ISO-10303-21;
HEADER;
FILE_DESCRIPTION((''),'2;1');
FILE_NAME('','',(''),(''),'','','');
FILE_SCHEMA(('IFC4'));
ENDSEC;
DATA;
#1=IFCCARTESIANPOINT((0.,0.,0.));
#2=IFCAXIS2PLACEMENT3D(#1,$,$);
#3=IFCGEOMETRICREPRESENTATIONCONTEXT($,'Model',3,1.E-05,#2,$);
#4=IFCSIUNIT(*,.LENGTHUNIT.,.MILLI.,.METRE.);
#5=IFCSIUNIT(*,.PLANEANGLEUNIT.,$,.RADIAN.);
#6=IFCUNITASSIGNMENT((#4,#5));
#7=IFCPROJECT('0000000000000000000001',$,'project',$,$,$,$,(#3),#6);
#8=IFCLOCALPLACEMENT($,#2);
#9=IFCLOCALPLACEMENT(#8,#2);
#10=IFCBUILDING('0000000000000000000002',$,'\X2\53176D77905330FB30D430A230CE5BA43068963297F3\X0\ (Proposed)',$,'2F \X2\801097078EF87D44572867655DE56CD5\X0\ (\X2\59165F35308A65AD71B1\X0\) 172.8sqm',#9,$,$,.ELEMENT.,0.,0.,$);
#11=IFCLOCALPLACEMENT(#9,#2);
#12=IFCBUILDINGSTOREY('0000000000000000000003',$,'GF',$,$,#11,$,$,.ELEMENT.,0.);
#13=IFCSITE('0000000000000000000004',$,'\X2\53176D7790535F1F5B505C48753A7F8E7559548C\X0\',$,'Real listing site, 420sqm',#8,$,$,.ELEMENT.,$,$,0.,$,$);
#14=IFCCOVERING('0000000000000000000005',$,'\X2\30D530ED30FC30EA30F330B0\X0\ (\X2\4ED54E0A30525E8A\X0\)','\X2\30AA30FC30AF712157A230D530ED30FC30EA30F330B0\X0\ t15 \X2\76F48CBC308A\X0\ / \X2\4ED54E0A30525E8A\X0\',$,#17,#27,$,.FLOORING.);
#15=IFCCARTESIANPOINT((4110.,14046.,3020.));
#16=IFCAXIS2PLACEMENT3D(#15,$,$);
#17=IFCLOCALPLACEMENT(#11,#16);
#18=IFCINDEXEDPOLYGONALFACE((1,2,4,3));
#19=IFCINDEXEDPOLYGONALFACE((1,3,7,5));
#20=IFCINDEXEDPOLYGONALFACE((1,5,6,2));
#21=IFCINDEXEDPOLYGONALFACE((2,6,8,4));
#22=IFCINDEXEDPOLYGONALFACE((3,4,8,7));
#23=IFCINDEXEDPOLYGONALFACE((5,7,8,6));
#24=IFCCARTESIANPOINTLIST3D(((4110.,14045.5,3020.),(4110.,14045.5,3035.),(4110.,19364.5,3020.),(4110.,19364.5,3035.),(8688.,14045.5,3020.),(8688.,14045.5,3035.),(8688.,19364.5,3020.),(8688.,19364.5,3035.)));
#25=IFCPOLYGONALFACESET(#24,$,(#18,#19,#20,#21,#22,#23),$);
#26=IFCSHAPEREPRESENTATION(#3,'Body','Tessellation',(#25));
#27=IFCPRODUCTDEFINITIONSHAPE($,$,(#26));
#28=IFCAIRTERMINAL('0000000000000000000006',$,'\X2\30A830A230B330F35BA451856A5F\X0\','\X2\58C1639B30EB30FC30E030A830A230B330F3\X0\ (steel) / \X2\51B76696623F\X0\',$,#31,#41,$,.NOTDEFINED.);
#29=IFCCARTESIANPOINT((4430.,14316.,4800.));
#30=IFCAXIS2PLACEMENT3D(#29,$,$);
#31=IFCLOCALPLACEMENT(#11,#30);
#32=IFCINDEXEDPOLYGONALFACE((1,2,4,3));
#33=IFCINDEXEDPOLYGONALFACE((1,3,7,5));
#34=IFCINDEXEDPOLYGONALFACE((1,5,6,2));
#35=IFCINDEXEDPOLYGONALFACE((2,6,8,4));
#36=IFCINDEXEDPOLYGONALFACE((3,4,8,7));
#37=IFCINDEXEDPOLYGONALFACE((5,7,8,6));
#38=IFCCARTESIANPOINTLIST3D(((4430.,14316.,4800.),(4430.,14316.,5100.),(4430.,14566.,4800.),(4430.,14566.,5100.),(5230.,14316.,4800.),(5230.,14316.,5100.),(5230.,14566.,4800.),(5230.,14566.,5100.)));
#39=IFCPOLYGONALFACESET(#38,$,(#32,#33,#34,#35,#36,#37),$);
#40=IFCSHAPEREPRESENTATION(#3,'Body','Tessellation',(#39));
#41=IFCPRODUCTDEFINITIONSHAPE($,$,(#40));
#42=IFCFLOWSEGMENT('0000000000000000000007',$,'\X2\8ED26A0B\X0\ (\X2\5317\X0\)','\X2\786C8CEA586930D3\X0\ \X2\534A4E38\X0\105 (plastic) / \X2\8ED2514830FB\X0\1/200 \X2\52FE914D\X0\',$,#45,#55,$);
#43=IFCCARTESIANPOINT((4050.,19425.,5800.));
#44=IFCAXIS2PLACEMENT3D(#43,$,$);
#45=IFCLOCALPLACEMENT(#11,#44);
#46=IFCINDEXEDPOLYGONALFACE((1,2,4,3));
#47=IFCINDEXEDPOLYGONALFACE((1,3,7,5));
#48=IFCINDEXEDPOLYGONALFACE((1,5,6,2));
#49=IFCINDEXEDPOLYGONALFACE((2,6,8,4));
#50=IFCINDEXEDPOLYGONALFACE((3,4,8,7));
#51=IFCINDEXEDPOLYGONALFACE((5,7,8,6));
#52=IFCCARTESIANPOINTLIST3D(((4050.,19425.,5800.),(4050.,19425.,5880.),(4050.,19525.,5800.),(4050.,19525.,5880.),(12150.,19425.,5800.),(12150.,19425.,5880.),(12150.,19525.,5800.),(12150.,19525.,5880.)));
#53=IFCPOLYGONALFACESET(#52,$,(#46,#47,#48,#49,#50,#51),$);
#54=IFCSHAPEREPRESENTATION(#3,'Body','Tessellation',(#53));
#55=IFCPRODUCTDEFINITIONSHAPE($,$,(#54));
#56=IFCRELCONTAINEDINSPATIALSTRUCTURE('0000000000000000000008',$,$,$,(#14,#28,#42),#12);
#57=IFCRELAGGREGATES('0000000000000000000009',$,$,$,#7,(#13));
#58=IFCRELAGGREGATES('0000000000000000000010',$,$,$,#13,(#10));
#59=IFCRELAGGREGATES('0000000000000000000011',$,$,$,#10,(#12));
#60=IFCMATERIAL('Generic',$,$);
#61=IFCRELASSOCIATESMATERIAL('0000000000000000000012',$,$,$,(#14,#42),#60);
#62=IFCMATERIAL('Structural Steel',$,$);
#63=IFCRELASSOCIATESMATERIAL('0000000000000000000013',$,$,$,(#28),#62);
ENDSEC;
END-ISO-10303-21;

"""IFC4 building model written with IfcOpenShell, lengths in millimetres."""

from ifc_helpers import new_model, si_unit, frame, frame_2d, origin, place, context, project, spatial, rectangle, extrude, material, element, save


model = new_model("IFC4")

# Units and contexts
model_context = context("Model", 3, precision=1e-05, world=origin())
ifc_project = project(units=[si_unit("LENGTHUNIT", "METRE", prefix="MILLI"), si_unit("PLANEANGLEUNIT", "RADIAN")], contexts=[model_context])

# Site, building, storey
site_placement = place(None, origin())
site = spatial("IfcSite", under=ifc_project, at=site_placement, Name="北海道弟子屈町美留和", ObjectType="Real listing site, 420sqm", CompositionType="ELEMENT", RefElevation=0.0)
building_placement = place(site_placement, origin())
building = spatial("IfcBuilding", under=site, at=building_placement, Name="北海道・ピアノ室と防音 (Proposed)", ObjectType="2F 耐震軸組在来工法 (外張り断熱) 172.8sqm", CompositionType="ELEMENT", ElevationOfRefHeight=0.0, ElevationOfTerrain=0.0)
storey_placement = place(building_placement, origin())
storey = spatial("IfcBuildingStorey", under=building, at=storey_placement, Name="GF", CompositionType="ELEMENT", Elevation=0.0)

# Shared definitions
ifc_material_1 = material(Name="Structural Steel")

# Covering
ifc_material_2 = material(Name="Generic")
covering_placement = place(storey_placement, frame((4110.0, 14046.0, 3020.0)))
element("IfcCovering", 1, at=covering_placement, inside=storey, material=ifc_material_2, Name="フローリング (仕上げ床)", Description="オーク無垢フローリング t15 直貼り / 仕上げ床", PredefinedType="FLOORING", context=model_context, shape_type="SweptSolid", body=[
    extrude(rectangle(XDim=4578.0, YDim=5319.0, at=frame_2d((2289.0, 2659.0))), frame((4110.0, 14046.0, 3020.0)), (0.0, 0.0, 1.0), 15.0),
])

# Air terminal
air_terminal_placement = place(storey_placement, frame((4430.0, 14316.0, 4800.0)))
element("IfcAirTerminal", 2, at=air_terminal_placement, inside=storey, material=ifc_material_1, Name="エアコン室内機", Description="壁掛ルームエアコン (steel) / 冷暖房", PredefinedType="NOTDEFINED", context=model_context, shape_type="SweptSolid", body=[
    extrude(rectangle(XDim=800.0, YDim=250.0, at=frame_2d((400.0, 125.0))), frame((4430.0, 14316.0, 4800.0)), (0.0, 0.0, 1.0), 300.0),
])

# Flow segment
flow_segment_placement = place(storey_placement, frame((4050.0, 19425.0, 5800.0)))
element("IfcFlowSegment", 3, at=flow_segment_placement, inside=storey, material=ifc_material_2, Name="軒樋 (北)", Description="硬質塩ビ 半丸105 (plastic) / 軒先・1/200 勾配", context=model_context, shape_type="SweptSolid", body=[
    extrude(rectangle(XDim=8100.0, YDim=100.0, at=frame_2d((4050.0, 50.0))), frame((4050.0, 19425.0, 5800.0)), (0.0, 0.0, 1.0), 80.0),
])

save(model, "model.ifc")
